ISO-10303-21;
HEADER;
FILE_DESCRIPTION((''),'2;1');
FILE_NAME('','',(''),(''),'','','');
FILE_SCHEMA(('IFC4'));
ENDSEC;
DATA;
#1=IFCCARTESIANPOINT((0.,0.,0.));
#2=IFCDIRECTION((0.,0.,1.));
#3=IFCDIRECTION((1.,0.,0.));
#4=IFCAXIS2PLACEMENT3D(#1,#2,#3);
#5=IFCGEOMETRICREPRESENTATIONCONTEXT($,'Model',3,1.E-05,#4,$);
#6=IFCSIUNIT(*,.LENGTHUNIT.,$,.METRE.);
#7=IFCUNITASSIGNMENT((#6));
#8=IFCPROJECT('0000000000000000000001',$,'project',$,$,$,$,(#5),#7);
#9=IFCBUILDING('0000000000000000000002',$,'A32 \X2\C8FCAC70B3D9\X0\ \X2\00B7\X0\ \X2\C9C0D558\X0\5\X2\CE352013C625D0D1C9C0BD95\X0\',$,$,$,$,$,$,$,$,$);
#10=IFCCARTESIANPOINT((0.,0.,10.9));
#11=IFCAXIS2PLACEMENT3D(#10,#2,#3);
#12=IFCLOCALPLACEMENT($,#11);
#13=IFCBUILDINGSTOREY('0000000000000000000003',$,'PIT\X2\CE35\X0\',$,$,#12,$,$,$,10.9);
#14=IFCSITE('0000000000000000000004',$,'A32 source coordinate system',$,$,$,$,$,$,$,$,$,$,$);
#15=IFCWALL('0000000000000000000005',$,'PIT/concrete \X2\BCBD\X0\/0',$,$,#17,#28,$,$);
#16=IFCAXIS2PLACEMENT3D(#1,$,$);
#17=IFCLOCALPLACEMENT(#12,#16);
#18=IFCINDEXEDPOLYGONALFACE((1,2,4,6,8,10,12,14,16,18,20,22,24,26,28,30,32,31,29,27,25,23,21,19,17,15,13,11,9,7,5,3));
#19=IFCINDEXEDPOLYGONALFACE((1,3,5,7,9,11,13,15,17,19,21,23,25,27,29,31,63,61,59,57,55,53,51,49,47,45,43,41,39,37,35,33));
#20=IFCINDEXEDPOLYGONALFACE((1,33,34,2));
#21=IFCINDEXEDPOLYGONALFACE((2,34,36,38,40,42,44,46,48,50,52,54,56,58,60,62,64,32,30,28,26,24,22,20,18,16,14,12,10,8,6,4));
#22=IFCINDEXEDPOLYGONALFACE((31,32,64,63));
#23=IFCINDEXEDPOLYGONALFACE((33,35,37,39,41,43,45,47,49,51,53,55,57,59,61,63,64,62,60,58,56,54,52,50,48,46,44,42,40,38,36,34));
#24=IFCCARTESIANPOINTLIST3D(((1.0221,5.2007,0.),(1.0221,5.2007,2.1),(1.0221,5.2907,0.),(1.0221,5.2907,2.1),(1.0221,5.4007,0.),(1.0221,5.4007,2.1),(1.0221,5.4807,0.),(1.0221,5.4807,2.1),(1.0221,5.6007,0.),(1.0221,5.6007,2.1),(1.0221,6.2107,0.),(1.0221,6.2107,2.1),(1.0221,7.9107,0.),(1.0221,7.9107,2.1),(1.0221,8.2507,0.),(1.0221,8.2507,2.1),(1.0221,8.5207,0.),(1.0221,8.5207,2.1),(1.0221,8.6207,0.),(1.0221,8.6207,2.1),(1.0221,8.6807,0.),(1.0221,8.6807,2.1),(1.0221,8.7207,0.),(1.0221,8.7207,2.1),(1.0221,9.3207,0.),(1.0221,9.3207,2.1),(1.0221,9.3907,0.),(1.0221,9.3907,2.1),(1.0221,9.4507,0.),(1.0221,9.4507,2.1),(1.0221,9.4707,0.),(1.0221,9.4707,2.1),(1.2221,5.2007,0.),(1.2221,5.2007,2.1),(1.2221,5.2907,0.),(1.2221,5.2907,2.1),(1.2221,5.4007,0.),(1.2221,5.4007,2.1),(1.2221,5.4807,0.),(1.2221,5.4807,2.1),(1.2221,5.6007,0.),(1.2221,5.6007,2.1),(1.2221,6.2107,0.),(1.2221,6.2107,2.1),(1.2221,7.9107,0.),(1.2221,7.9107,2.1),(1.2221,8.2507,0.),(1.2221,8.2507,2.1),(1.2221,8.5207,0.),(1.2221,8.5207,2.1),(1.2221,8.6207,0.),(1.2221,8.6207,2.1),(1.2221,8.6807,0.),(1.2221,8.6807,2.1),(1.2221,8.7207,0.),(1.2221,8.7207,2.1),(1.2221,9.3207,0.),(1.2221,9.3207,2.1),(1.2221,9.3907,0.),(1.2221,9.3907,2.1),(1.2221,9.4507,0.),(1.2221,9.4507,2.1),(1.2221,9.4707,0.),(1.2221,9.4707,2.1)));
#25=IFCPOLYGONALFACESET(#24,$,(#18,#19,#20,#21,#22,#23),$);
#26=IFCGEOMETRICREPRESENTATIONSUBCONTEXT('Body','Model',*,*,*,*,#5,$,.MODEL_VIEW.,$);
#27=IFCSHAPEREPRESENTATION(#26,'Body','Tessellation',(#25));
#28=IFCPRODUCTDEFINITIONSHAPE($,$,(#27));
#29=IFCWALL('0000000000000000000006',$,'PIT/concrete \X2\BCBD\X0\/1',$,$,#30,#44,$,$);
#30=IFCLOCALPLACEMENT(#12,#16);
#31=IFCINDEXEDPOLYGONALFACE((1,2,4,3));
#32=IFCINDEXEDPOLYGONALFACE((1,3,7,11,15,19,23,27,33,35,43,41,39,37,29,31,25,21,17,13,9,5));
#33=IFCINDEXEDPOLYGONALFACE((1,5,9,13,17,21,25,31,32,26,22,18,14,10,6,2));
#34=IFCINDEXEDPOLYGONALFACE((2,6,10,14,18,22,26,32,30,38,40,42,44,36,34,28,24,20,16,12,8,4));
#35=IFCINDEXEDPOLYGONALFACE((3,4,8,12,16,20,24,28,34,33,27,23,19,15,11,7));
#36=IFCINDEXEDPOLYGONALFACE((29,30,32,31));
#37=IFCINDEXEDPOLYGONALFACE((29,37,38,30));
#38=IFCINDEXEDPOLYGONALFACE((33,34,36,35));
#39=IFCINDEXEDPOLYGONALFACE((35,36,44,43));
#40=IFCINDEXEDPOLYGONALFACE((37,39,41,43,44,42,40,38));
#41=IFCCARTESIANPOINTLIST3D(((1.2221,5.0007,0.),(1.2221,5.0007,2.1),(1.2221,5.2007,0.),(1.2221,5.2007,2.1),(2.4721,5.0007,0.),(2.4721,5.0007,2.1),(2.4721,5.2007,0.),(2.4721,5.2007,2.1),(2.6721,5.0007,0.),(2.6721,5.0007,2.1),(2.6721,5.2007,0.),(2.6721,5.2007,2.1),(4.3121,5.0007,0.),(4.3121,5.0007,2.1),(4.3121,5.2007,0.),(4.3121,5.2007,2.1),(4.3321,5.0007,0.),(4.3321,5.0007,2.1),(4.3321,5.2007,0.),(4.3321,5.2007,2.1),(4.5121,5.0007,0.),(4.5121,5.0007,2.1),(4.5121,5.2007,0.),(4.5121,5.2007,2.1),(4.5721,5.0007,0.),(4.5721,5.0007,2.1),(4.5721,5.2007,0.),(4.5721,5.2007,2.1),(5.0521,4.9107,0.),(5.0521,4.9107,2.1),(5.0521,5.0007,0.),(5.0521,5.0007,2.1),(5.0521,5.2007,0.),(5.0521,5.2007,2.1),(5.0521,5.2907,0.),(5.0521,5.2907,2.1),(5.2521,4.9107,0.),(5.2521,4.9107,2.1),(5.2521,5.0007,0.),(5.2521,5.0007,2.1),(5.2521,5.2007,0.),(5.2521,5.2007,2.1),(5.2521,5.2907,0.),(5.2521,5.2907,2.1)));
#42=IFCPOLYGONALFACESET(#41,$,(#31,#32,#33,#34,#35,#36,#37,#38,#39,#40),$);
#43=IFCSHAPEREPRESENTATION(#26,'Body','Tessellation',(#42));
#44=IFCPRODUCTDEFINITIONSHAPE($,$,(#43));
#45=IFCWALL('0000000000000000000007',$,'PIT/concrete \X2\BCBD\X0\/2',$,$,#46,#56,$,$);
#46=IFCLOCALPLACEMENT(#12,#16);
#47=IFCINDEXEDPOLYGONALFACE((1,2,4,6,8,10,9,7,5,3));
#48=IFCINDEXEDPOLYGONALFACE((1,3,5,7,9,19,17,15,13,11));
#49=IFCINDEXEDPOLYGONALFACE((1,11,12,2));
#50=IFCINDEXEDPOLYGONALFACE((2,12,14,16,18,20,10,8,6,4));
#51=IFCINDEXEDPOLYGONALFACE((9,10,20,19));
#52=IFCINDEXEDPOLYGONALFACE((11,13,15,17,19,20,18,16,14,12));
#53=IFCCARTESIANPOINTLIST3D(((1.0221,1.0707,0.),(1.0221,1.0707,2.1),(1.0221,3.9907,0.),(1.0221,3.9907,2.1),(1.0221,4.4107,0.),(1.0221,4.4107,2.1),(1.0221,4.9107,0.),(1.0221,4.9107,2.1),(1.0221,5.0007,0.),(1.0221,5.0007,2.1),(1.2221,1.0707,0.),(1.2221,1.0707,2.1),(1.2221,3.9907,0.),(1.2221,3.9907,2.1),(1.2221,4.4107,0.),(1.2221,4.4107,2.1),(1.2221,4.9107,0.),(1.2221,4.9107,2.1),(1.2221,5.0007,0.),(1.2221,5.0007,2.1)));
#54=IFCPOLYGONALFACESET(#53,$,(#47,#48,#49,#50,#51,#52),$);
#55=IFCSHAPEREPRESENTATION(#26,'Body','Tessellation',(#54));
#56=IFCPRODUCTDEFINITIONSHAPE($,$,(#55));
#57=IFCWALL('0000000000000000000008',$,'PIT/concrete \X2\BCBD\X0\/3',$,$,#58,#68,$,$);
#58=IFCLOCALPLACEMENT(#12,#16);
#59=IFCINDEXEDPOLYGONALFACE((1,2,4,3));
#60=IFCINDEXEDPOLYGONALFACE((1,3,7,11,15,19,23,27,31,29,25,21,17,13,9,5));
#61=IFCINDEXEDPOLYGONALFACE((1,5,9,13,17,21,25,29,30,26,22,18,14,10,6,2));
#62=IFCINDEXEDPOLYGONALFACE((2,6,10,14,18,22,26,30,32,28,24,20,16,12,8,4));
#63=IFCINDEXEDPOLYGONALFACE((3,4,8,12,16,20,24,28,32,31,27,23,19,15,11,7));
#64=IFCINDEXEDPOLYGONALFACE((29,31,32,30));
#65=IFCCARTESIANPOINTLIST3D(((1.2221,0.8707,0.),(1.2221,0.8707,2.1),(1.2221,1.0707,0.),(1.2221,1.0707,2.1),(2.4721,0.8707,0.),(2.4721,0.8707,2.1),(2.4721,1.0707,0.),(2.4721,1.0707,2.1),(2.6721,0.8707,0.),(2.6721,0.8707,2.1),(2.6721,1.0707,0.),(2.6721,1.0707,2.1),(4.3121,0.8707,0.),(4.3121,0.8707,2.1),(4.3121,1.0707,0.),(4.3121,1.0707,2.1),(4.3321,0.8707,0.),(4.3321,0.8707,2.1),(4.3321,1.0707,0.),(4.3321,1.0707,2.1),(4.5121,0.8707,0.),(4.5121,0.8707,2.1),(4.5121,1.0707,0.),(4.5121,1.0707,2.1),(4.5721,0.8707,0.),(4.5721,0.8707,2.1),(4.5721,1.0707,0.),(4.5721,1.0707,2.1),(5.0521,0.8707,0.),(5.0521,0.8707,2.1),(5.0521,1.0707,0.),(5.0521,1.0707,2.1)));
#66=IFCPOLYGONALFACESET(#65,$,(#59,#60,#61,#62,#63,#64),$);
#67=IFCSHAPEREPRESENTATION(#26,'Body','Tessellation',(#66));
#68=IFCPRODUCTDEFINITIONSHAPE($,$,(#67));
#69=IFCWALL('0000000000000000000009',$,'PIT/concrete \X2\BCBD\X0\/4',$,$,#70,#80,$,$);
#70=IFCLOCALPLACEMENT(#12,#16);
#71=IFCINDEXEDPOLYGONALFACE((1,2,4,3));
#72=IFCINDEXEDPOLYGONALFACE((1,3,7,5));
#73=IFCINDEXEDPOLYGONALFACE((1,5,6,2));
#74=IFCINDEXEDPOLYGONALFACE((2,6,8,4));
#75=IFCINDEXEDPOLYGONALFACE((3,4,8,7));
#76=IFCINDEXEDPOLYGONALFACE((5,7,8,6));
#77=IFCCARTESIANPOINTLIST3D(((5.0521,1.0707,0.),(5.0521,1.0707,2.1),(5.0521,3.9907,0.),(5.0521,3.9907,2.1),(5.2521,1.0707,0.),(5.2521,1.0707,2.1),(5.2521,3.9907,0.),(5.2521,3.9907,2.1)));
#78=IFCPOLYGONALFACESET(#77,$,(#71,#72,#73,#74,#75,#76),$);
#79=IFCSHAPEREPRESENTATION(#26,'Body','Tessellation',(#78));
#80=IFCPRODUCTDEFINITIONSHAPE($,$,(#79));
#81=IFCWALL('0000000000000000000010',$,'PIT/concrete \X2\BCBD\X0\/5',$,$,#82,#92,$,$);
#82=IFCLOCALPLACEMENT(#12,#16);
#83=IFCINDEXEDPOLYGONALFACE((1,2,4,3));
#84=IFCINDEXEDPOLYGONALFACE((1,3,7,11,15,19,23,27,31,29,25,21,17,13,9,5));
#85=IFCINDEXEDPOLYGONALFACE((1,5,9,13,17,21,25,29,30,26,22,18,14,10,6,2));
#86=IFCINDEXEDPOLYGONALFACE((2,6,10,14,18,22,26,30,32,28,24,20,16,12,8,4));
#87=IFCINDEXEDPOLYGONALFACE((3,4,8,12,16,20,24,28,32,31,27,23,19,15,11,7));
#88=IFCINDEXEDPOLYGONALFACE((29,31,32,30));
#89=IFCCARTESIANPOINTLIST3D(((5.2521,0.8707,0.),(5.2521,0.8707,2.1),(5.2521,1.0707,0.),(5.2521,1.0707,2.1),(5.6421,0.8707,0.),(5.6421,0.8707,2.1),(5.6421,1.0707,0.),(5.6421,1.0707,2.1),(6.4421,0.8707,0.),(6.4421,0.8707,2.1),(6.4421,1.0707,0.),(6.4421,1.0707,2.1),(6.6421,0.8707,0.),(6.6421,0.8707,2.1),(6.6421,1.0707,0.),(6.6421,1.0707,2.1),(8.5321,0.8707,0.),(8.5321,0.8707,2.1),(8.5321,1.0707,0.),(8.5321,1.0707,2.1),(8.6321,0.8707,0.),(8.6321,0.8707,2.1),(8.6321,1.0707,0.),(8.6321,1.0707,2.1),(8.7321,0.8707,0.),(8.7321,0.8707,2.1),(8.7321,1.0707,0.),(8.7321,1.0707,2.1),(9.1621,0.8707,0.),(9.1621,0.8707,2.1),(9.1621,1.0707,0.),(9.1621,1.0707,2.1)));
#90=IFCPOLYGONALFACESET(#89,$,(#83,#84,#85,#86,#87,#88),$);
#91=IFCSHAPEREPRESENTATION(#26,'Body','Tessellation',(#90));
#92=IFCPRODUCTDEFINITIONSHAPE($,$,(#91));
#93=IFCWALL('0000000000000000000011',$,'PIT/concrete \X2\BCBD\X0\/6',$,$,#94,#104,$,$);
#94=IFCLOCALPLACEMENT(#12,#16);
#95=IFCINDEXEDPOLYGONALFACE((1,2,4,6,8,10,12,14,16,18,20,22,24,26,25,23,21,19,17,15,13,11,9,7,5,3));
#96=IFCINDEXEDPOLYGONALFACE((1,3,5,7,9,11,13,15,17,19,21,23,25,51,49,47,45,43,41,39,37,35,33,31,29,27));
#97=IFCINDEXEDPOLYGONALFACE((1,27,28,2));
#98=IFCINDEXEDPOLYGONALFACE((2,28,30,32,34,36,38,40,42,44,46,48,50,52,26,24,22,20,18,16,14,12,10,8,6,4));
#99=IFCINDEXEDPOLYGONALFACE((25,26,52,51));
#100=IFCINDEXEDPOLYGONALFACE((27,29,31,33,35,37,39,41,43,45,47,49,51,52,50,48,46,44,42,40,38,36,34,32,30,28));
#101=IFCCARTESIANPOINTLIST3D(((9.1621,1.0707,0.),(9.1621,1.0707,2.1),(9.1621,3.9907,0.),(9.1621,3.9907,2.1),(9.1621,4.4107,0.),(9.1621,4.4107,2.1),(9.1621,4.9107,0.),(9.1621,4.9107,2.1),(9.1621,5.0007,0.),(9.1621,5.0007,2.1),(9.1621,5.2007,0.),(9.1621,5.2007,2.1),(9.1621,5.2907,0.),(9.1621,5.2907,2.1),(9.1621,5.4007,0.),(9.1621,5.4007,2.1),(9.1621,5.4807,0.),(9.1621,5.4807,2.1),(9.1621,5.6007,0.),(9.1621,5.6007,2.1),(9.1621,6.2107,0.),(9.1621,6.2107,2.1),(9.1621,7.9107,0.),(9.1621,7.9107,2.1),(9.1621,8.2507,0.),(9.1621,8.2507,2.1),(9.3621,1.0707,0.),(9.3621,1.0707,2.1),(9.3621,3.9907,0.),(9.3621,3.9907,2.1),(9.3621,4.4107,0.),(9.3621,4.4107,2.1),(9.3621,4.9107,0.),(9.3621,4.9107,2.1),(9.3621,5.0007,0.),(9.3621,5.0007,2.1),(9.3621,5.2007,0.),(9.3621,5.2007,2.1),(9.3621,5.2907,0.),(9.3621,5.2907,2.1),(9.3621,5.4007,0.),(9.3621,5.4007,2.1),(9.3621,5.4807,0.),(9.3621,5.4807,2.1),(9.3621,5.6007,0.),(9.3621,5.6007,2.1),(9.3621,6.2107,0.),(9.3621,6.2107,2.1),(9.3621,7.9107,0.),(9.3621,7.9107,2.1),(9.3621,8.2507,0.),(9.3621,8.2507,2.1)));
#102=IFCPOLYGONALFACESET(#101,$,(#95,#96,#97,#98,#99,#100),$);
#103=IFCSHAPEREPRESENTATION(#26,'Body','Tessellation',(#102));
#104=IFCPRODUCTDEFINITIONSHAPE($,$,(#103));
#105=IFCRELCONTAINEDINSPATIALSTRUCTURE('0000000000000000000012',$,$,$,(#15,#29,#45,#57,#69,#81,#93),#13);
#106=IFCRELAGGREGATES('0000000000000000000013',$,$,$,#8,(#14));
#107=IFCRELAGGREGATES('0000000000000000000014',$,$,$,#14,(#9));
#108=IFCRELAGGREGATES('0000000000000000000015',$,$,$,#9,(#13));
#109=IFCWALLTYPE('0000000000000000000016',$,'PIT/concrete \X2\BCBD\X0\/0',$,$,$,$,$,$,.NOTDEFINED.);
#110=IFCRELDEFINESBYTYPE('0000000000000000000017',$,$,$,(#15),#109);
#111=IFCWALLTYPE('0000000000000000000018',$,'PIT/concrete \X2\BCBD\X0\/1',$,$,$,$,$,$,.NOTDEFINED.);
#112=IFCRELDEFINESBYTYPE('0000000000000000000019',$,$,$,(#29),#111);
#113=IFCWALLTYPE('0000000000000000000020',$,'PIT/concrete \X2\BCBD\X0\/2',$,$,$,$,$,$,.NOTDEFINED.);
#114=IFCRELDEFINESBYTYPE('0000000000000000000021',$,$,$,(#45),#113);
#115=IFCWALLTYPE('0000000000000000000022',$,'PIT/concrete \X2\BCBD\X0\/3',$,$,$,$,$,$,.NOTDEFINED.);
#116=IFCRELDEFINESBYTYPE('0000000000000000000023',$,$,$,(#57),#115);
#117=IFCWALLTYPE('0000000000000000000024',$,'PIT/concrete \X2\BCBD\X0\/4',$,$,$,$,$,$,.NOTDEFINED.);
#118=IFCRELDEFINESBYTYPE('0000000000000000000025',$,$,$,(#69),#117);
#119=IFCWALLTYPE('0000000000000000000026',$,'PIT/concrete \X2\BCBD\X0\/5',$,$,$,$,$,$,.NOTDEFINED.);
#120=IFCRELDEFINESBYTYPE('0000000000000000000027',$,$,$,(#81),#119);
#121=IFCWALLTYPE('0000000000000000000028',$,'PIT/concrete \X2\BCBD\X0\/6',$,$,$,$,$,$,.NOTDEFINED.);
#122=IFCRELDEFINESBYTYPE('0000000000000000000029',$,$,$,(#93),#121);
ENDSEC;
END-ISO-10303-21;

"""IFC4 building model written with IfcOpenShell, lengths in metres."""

from ifc_helpers import new_model, si_unit, frame, origin, origin_with_axes, place, context, subcontext, project, spatial, polyline, outline, extrude, source, transform, mapped, type_object, type_shapes, element, save


model = new_model("IFC4")

# Units and contexts
model_context = context("Model", 3, precision=1e-05, world=origin_with_axes())
body_context = subcontext(model_context, "Body", "Model", "MODEL_VIEW")
ifc_project = project(units=[si_unit("LENGTHUNIT", "METRE")], contexts=[model_context])

# Site, building, storey
site = spatial("IfcSite", under=ifc_project, Name="A32 source coordinate system")
building = spatial("IfcBuilding", under=site, Name="A32 주거동 · 지하5층–옥탑지붕")
storey_placement = place(None, frame((0.0, 0.0, 10.9), z_axis=(0.0, 0.0, 1.0), x_axis=(1.0, 0.0, 0.0)))
storey = spatial("IfcBuildingStorey", under=building, at=storey_placement, Name="PIT층", Elevation=10.9)

# Walls
wall_type_1 = type_object("IfcWallType", Name="PIT/concrete 벽/0", PredefinedType="NOTDEFINED")
shared_shape_1 = source(origin(), body_context, "Body", "SweptSolid", [
    extrude(outline(polyline([(1.0221, 8.6207), (1.0221, 8.6807), (1.0221, 8.7207), (1.0221, 9.3207), (1.0221, 9.3907), (1.0221, 9.4507), (1.0221, 9.4707), (1.2221, 9.4707), (1.2221, 9.4507), (1.2221, 9.3907), (1.2221, 9.3207), (1.2221, 8.7207), (1.2221, 8.6807), (1.2221, 8.6207), (1.2221, 8.5207), (1.2221, 8.2507), (1.2221, 7.9107), (1.2221, 6.2107), (1.2221, 5.6007), (1.2221, 5.4807), (1.2221, 5.4007), (1.2221, 5.2907), (1.2221, 5.2007), (1.0221, 5.2007), (1.0221, 5.2907), (1.0221, 5.4007), (1.0221, 5.4807), (1.0221, 5.6007), (1.0221, 6.2107), (1.0221, 7.9107), (1.0221, 8.2507), (1.0221, 8.5207), (1.0221, 8.6207)])), origin(), (0.0, 0.0, 1.0), 2.1),
])
type_shapes(wall_type_1, [shared_shape_1])
wall_1_placement = place(storey_placement, origin_with_axes())
element("IfcWall", 1, at=wall_1_placement, inside=storey, type_object=wall_type_1, Name="PIT/concrete 벽/0", context=body_context, shape_type="MappedRepresentation", body=[
    mapped(shared_shape_1, transform((0.0, 0.0, 0.0), scale=1.0)),
])
wall_type_2 = type_object("IfcWallType", Name="PIT/concrete 벽/1", PredefinedType="NOTDEFINED")
shared_shape_2 = source(origin(), body_context, "Body", "SweptSolid", [
    extrude(outline(polyline([(4.3121, 5.2007), (4.3321, 5.2007), (4.5121, 5.2007), (4.5721, 5.2007), (5.0521, 5.2007), (5.0521, 5.2907), (5.2521, 5.2907), (5.2521, 5.2007), (5.2521, 5.0007), (5.2521, 4.9107), (5.0521, 4.9107), (5.0521, 5.0007), (4.5721, 5.0007), (4.5121, 5.0007), (4.3321, 5.0007), (4.3121, 5.0007), (2.6721, 5.0007), (2.4721, 5.0007), (1.2221, 5.0007), (1.2221, 5.2007), (2.4721, 5.2007), (2.6721, 5.2007), (4.3121, 5.2007)])), origin(), (0.0, 0.0, 1.0), 2.1),
])
type_shapes(wall_type_2, [shared_shape_2])
wall_2_placement = place(storey_placement, origin_with_axes())
element("IfcWall", 2, at=wall_2_placement, inside=storey, type_object=wall_type_2, Name="PIT/concrete 벽/1", context=body_context, shape_type="MappedRepresentation", body=[
    mapped(shared_shape_2, transform((0.0, 0.0, 0.0), scale=1.0)),
])
wall_type_3 = type_object("IfcWallType", Name="PIT/concrete 벽/2", PredefinedType="NOTDEFINED")
shared_shape_3 = source(origin(), body_context, "Body", "SweptSolid", [
    extrude(outline(polyline([(1.2221, 3.9907), (1.2221, 1.0707), (1.0221, 1.0707), (1.0221, 3.9907), (1.0221, 4.4107), (1.0221, 4.9107), (1.0221, 5.0007), (1.2221, 5.0007), (1.2221, 4.9107), (1.2221, 4.4107), (1.2221, 3.9907)])), origin(), (0.0, 0.0, 1.0), 2.1),
])
type_shapes(wall_type_3, [shared_shape_3])
wall_3_placement = place(storey_placement, origin_with_axes())
element("IfcWall", 3, at=wall_3_placement, inside=storey, type_object=wall_type_3, Name="PIT/concrete 벽/2", context=body_context, shape_type="MappedRepresentation", body=[
    mapped(shared_shape_3, transform((0.0, 0.0, 0.0), scale=1.0)),
])
wall_type_4 = type_object("IfcWallType", Name="PIT/concrete 벽/3", PredefinedType="NOTDEFINED")
shared_shape_4 = source(origin(), body_context, "Body", "SweptSolid", [
    extrude(outline(polyline([(4.3121, 1.0707), (4.3321, 1.0707), (4.5121, 1.0707), (4.5721, 1.0707), (5.0521, 1.0707), (5.0521, 0.8707), (4.5721, 0.8707), (4.5121, 0.8707), (4.3321, 0.8707), (4.3121, 0.8707), (2.6721, 0.8707), (2.4721, 0.8707), (1.2221, 0.8707), (1.2221, 1.0707), (2.4721, 1.0707), (2.6721, 1.0707), (4.3121, 1.0707)])), origin(), (0.0, 0.0, 1.0), 2.1),
])
type_shapes(wall_type_4, [shared_shape_4])
wall_4_placement = place(storey_placement, origin_with_axes())
element("IfcWall", 4, at=wall_4_placement, inside=storey, type_object=wall_type_4, Name="PIT/concrete 벽/3", context=body_context, shape_type="MappedRepresentation", body=[
    mapped(shared_shape_4, transform((0.0, 0.0, 0.0), scale=1.0)),
])
wall_type_5 = type_object("IfcWallType", Name="PIT/concrete 벽/4", PredefinedType="NOTDEFINED")
shared_shape_5 = source(origin(), body_context, "Body", "SweptSolid", [
    extrude(outline(polyline([(5.2521, 1.0707), (5.0521, 1.0707), (5.0521, 3.9907), (5.2521, 3.9907), (5.2521, 1.0707)])), origin(), (0.0, 0.0, 1.0), 2.1),
])
type_shapes(wall_type_5, [shared_shape_5])
wall_5_placement = place(storey_placement, origin_with_axes())
element("IfcWall", 5, at=wall_5_placement, inside=storey, type_object=wall_type_5, Name="PIT/concrete 벽/4", context=body_context, shape_type="MappedRepresentation", body=[
    mapped(shared_shape_5, transform((0.0, 0.0, 0.0), scale=1.0)),
])
wall_type_6 = type_object("IfcWallType", Name="PIT/concrete 벽/5", PredefinedType="NOTDEFINED")
shared_shape_6 = source(origin(), body_context, "Body", "SweptSolid", [
    extrude(outline(polyline([(6.6421, 1.0707), (8.5321, 1.0707), (8.6321, 1.0707), (8.7321, 1.0707), (9.1621, 1.0707), (9.1621, 0.8707), (8.7321, 0.8707), (8.6321, 0.8707), (8.5321, 0.8707), (6.6421, 0.8707), (6.4421, 0.8707), (5.6421, 0.8707), (5.2521, 0.8707), (5.2521, 1.0707), (5.6421, 1.0707), (6.4421, 1.0707), (6.6421, 1.0707)])), origin(), (0.0, 0.0, 1.0), 2.1),
])
type_shapes(wall_type_6, [shared_shape_6])
wall_6_placement = place(storey_placement, origin_with_axes())
element("IfcWall", 6, at=wall_6_placement, inside=storey, type_object=wall_type_6, Name="PIT/concrete 벽/5", context=body_context, shape_type="MappedRepresentation", body=[
    mapped(shared_shape_6, transform((0.0, 0.0, 0.0), scale=1.0)),
])
wall_type_7 = type_object("IfcWallType", Name="PIT/concrete 벽/6", PredefinedType="NOTDEFINED")
shared_shape_7 = source(origin(), body_context, "Body", "SweptSolid", [
    extrude(outline(polyline([(9.1621, 4.9107), (9.1621, 5.0007), (9.1621, 5.2007), (9.1621, 5.2907), (9.1621, 5.4007), (9.1621, 5.4807), (9.1621, 5.6007), (9.1621, 6.2107), (9.1621, 7.9107), (9.1621, 8.2507), (9.3621, 8.2507), (9.3621, 7.9107), (9.3621, 6.2107), (9.3621, 5.6007), (9.3621, 5.4807), (9.3621, 5.4007), (9.3621, 5.2907), (9.3621, 5.2007), (9.3621, 5.0007), (9.3621, 4.9107), (9.3621, 4.4107), (9.3621, 3.9907), (9.3621, 1.0707), (9.1621, 1.0707), (9.1621, 3.9907), (9.1621, 4.4107), (9.1621, 4.9107)])), origin(), (0.0, 0.0, 1.0), 2.1),
])
type_shapes(wall_type_7, [shared_shape_7])
wall_7_placement = place(storey_placement, origin_with_axes())
element("IfcWall", 7, at=wall_7_placement, inside=storey, type_object=wall_type_7, Name="PIT/concrete 벽/6", context=body_context, shape_type="MappedRepresentation", body=[
    mapped(shared_shape_7, transform((0.0, 0.0, 0.0), scale=1.0)),
])

save(model, "model.ifc")
